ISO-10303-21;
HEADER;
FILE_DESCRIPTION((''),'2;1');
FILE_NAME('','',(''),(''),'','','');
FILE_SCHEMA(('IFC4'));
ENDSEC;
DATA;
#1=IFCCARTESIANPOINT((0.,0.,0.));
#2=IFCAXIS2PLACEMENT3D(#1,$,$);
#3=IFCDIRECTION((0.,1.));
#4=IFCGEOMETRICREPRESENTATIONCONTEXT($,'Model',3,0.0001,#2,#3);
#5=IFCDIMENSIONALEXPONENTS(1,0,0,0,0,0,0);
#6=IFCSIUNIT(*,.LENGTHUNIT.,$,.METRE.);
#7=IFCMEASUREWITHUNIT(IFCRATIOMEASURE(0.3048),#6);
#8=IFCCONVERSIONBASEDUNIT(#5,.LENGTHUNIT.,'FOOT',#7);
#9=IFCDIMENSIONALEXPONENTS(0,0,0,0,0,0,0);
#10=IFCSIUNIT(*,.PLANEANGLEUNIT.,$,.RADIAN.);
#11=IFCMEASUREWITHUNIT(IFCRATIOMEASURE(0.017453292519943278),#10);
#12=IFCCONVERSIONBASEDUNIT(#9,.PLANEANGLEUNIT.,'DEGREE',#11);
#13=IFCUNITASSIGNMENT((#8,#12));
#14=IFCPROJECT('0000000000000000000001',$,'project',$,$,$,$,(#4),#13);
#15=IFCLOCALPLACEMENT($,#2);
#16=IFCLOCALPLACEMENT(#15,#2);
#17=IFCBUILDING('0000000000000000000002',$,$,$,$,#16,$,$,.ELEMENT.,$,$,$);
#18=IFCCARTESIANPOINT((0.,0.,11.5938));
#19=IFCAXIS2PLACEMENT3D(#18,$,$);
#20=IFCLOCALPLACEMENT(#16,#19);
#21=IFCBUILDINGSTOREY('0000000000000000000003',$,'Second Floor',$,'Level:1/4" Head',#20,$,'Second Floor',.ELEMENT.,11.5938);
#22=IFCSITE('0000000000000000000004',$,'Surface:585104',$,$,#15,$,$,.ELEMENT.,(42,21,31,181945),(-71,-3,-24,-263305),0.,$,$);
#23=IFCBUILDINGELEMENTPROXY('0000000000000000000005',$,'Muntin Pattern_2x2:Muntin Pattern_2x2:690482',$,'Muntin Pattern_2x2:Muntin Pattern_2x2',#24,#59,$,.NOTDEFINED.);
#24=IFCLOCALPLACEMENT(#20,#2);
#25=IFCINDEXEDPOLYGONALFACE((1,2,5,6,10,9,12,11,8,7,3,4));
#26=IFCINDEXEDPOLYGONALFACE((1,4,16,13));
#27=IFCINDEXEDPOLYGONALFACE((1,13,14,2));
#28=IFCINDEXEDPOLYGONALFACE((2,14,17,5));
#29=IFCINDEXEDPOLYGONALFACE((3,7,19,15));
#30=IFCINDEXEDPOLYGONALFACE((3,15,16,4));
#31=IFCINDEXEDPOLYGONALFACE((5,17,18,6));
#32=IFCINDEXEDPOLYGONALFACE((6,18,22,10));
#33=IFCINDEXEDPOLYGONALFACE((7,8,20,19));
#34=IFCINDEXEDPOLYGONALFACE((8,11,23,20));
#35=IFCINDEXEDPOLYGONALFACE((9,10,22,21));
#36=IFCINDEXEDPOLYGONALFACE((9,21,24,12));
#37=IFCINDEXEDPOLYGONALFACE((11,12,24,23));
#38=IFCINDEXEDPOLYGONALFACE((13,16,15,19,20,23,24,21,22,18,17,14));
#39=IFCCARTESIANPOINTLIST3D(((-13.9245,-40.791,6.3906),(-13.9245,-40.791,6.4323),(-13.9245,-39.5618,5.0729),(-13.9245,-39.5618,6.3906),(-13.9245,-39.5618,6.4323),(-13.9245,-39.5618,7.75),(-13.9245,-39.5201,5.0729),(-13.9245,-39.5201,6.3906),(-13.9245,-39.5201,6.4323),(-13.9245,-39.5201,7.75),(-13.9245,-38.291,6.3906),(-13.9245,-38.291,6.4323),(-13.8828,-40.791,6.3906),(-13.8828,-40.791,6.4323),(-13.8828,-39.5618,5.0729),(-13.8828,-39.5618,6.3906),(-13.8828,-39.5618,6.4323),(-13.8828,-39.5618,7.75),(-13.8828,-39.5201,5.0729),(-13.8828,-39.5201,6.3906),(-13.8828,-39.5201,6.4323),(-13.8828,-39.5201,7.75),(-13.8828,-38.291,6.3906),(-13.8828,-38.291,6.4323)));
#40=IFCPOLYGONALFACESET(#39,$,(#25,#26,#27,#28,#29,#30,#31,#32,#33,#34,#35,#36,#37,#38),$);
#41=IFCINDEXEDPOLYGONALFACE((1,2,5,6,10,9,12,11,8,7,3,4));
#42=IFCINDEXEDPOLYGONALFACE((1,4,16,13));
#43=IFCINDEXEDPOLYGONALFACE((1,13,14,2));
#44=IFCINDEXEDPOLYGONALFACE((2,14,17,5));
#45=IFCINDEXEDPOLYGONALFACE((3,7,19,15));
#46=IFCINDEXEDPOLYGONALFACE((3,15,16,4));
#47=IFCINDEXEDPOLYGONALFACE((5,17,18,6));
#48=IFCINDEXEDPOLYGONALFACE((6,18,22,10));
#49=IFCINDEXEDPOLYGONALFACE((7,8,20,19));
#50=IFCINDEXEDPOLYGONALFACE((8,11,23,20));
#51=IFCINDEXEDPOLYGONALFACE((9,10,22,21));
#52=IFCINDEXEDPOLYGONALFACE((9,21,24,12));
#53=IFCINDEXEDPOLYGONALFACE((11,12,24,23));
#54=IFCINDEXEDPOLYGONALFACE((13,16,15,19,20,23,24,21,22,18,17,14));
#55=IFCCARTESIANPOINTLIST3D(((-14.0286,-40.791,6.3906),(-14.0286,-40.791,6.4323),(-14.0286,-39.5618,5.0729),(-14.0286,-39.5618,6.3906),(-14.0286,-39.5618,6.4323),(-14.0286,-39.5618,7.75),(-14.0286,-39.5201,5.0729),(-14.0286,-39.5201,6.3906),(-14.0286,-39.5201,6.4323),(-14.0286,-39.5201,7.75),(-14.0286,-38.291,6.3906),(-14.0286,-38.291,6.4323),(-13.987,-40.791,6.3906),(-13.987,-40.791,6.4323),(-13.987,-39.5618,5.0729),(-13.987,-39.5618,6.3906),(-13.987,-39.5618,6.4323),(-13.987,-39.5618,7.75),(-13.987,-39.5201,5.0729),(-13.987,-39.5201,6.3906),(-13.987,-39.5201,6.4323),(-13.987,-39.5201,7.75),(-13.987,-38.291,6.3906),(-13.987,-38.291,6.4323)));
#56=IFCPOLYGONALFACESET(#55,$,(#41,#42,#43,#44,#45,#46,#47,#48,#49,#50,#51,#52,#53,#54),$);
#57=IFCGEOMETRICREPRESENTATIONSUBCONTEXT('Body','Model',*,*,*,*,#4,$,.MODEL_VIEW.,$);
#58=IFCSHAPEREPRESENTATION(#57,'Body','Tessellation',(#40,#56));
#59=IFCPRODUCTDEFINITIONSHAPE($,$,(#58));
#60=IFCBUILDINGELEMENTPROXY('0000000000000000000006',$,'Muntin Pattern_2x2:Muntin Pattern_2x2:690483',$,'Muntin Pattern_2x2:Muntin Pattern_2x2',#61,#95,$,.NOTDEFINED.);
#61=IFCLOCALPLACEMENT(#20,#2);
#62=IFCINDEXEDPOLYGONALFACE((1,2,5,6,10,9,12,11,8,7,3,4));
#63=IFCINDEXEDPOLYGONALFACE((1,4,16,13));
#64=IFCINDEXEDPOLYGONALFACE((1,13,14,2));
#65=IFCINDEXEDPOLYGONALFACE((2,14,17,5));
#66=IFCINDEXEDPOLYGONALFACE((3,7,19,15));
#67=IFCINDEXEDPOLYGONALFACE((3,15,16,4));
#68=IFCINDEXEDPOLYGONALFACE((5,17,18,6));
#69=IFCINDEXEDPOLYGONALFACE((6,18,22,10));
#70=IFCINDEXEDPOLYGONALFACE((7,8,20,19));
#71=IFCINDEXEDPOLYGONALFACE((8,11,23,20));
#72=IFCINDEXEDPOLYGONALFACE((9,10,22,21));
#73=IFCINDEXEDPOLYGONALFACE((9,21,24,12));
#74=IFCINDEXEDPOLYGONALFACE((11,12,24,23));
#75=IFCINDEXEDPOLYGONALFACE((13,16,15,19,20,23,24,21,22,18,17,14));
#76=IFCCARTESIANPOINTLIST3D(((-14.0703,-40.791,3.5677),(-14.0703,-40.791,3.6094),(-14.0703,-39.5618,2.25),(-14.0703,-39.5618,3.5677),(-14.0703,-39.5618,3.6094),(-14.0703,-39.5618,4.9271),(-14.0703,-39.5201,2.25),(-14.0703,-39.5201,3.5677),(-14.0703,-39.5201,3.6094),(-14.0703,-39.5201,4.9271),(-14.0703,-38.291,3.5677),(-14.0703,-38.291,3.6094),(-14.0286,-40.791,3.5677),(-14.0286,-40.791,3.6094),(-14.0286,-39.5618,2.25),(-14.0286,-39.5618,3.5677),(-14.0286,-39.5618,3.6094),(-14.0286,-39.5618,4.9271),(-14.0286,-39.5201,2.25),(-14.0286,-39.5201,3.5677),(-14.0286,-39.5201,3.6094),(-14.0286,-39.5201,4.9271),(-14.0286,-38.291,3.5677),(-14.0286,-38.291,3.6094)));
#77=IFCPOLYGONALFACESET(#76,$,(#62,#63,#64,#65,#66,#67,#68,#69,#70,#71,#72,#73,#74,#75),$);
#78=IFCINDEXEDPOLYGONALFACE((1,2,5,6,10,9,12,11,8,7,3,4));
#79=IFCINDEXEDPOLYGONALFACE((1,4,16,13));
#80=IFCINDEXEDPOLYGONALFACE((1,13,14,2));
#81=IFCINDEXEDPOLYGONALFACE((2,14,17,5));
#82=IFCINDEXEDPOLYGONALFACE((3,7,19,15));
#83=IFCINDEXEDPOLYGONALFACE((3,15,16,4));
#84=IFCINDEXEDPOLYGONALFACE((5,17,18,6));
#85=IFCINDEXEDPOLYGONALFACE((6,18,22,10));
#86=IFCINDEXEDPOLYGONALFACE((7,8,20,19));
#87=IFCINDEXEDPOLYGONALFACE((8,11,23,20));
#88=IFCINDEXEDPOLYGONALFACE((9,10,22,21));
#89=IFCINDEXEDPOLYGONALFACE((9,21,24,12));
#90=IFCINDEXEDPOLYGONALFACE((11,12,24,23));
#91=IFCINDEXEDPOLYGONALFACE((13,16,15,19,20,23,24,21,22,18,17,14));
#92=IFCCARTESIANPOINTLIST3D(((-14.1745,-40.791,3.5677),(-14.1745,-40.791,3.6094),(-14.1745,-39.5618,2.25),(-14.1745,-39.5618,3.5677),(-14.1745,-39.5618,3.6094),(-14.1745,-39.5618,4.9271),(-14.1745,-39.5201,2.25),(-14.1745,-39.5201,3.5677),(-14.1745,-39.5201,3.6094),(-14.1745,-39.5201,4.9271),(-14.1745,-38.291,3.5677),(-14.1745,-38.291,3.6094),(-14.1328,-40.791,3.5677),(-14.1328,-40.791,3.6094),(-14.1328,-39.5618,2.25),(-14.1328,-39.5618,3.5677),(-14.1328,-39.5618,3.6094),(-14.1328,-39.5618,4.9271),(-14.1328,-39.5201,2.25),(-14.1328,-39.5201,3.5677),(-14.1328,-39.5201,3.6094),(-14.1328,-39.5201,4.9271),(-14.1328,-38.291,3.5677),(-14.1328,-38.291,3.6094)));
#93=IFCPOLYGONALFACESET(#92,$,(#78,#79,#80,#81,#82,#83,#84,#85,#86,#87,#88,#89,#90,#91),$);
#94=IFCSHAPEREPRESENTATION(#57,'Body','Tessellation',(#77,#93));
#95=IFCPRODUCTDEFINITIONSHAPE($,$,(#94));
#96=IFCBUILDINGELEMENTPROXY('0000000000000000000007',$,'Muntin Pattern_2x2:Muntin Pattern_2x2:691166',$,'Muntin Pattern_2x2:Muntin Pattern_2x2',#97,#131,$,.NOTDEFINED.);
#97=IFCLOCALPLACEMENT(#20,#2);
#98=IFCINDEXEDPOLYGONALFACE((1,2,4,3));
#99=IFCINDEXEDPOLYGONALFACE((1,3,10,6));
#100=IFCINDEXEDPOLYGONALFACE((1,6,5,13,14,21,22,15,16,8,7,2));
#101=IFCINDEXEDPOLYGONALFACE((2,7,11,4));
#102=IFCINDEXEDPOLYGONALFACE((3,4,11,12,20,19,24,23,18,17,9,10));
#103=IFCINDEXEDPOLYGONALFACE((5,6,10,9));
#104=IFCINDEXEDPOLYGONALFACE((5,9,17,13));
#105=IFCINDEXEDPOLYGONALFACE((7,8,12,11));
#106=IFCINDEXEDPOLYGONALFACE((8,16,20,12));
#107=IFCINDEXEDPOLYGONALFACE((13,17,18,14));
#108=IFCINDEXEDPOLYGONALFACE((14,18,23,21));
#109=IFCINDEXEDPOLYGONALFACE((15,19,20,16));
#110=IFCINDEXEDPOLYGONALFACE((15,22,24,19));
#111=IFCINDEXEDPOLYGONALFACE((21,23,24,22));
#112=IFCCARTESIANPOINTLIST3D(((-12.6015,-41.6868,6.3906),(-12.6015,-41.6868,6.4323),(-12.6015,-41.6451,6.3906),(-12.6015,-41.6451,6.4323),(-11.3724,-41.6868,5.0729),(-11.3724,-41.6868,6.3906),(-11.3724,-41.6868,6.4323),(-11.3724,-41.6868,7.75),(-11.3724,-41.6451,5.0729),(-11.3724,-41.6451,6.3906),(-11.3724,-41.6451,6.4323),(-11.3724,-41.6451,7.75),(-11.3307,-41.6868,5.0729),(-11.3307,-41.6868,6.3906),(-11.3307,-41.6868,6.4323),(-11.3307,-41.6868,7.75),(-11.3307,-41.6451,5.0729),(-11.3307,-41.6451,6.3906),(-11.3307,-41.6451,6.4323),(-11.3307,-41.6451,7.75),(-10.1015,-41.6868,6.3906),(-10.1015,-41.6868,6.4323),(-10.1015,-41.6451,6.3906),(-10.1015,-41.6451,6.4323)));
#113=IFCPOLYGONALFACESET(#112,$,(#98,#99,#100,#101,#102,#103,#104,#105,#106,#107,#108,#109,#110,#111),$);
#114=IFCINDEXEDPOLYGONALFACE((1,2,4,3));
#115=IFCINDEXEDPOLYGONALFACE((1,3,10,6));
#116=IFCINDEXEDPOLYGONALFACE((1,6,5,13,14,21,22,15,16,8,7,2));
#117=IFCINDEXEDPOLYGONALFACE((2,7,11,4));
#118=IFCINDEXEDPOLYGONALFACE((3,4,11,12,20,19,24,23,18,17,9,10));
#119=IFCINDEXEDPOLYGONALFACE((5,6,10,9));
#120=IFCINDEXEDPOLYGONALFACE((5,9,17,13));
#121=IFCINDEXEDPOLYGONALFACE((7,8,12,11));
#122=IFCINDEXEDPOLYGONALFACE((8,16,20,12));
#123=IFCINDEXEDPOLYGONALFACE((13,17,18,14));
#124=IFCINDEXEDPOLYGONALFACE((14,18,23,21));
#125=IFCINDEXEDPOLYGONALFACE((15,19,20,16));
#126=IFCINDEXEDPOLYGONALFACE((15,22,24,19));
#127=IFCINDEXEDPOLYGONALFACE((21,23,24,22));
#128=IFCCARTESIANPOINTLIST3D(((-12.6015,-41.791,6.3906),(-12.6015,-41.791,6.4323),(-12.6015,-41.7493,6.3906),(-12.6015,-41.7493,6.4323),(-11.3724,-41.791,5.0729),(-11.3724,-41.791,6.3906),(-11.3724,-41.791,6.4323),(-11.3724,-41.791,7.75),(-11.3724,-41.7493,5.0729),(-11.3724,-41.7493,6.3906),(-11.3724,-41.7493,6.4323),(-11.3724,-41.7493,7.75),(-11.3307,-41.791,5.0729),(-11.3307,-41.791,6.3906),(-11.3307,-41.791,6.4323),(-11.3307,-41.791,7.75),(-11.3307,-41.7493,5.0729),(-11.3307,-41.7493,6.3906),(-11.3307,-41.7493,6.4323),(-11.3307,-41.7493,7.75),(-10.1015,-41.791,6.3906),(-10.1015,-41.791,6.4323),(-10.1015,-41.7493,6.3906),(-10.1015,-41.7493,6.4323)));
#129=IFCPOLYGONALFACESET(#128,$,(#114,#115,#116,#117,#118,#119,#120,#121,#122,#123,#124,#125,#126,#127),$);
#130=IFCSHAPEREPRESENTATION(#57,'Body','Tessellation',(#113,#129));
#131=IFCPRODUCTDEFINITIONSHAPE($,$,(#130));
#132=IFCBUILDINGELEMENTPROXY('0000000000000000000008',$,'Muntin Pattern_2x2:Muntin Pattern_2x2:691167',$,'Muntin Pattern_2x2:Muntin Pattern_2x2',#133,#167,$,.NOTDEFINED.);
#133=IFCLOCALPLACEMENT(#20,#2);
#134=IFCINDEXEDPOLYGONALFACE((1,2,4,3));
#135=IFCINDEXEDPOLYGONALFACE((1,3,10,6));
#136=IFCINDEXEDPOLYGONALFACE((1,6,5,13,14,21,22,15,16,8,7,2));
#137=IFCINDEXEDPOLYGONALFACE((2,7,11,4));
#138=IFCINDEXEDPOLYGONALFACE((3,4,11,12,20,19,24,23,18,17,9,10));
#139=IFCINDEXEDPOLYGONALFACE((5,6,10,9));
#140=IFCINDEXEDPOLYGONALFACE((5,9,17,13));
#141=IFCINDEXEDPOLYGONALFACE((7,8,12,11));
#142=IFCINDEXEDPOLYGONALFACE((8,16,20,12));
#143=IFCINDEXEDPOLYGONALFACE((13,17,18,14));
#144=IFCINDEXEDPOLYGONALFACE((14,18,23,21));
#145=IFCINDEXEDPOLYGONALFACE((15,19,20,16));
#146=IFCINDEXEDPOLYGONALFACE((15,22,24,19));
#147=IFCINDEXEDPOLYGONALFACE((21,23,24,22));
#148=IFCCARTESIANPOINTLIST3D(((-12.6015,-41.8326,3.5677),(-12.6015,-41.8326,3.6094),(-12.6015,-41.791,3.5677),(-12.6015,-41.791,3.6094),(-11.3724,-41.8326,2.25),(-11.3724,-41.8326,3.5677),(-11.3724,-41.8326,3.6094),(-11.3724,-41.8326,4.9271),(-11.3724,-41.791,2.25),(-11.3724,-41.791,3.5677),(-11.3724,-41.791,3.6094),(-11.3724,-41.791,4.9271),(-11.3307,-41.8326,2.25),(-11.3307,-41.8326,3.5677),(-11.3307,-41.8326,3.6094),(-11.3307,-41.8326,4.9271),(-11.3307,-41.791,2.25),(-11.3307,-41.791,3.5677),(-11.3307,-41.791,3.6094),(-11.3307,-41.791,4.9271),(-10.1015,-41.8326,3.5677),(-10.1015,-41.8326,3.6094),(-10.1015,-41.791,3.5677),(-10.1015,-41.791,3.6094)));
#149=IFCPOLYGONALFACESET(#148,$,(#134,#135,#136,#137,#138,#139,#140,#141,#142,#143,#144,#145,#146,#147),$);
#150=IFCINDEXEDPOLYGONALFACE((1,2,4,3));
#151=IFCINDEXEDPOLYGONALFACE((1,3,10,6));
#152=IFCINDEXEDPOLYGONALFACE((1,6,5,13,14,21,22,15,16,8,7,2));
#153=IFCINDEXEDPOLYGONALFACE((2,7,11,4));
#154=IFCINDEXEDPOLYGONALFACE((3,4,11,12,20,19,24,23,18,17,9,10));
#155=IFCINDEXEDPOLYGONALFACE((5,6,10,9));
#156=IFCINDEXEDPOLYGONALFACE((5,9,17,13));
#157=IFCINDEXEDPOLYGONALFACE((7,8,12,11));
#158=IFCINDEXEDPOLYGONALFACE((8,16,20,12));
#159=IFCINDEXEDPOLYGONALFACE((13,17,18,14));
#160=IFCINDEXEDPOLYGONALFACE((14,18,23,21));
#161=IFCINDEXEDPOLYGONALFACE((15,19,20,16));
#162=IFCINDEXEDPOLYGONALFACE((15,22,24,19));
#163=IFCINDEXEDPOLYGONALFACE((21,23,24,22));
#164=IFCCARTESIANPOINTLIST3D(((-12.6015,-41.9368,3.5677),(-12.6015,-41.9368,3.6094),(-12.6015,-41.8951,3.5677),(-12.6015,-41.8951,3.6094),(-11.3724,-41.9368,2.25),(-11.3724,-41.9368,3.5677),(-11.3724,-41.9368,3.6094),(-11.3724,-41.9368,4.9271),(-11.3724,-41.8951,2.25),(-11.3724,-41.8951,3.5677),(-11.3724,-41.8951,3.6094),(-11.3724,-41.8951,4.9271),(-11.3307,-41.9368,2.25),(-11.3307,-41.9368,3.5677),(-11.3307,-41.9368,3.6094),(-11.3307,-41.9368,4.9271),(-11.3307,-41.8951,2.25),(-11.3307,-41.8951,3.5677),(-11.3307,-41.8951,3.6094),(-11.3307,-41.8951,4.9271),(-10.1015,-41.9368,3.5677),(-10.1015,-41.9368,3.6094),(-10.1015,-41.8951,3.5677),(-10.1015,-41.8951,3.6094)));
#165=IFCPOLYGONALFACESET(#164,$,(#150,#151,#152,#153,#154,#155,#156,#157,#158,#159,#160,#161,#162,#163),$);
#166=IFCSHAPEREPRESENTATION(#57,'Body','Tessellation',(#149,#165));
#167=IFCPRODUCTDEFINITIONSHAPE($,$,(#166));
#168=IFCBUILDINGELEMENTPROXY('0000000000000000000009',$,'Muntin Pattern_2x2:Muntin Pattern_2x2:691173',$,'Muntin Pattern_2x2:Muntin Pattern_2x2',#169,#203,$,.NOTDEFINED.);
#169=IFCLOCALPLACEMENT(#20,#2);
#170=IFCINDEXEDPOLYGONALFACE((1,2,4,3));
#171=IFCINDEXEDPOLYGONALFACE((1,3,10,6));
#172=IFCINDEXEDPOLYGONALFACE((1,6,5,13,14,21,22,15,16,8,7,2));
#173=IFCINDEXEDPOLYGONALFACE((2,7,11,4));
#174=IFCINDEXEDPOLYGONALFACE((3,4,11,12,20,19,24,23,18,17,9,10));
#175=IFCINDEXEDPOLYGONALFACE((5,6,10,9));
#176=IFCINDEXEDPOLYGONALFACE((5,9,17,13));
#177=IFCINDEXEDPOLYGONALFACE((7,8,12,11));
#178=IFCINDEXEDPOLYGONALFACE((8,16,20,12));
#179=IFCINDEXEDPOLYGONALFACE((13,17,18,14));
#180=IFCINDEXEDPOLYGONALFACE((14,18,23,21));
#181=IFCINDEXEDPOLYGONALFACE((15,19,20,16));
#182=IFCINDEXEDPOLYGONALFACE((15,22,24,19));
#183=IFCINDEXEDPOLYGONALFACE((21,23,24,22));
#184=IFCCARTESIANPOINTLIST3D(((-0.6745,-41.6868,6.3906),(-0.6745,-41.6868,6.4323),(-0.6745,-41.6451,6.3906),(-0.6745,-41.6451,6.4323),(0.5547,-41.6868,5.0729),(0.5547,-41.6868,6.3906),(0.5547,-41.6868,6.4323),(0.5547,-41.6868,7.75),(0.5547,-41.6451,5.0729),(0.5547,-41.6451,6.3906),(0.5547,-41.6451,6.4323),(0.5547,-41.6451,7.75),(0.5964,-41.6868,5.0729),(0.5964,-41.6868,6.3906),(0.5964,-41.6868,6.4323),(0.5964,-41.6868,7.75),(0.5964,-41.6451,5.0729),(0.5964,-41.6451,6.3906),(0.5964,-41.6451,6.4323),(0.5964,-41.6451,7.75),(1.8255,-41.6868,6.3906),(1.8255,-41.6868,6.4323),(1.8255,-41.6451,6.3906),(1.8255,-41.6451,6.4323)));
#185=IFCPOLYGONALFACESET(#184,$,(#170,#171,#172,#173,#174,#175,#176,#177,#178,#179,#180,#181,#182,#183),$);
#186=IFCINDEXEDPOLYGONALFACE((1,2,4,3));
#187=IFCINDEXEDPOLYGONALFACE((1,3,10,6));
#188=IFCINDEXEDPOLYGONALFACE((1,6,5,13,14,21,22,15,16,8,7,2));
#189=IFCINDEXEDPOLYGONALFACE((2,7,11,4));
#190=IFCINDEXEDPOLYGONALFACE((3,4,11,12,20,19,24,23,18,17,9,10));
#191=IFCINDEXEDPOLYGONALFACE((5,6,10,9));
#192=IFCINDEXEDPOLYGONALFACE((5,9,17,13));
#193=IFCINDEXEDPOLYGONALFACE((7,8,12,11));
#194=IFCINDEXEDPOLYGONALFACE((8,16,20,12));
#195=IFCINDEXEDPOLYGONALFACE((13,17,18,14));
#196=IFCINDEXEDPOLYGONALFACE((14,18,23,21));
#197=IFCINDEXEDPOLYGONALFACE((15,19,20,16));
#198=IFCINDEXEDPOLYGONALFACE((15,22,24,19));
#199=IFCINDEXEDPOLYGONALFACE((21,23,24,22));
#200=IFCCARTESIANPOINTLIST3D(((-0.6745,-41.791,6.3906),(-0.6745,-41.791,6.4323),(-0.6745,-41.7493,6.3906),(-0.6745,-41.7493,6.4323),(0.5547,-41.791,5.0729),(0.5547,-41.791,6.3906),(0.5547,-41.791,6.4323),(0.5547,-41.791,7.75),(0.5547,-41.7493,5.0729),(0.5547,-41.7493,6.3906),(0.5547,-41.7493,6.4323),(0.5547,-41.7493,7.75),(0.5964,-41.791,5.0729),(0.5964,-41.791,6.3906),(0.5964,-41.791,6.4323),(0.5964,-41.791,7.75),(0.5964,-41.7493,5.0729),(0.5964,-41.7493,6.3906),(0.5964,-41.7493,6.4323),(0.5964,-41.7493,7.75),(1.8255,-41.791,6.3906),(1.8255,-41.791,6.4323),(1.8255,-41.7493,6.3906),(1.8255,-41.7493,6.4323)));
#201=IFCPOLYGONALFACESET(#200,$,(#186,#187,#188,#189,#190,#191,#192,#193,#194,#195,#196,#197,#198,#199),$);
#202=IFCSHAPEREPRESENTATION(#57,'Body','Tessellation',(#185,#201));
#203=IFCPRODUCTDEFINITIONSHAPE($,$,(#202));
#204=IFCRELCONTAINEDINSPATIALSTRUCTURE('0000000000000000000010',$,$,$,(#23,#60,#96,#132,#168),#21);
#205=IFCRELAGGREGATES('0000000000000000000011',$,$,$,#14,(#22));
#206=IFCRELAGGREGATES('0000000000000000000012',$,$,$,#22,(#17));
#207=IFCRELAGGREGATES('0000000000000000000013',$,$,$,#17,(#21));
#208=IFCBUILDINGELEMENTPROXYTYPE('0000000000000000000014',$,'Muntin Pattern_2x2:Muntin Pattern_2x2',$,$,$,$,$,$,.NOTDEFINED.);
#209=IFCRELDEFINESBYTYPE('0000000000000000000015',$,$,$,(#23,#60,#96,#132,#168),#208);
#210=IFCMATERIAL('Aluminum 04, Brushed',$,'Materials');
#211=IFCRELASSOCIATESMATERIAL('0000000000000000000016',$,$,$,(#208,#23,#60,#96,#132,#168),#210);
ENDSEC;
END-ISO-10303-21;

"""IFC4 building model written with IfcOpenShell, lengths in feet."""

from ifc_helpers import new_model, entity, si_unit, converted_unit, direction, frame, origin, place, context, subcontext, project, spatial, indexed_curve, outline, extrude, source, transform, mapped, material, type_object, type_shapes, element, save


model = new_model("IFC4")

# Units and contexts
model_context = context("Model", 3, precision=0.0001, world=origin(), true_north=direction((0.0, 1.0)))
body_context = subcontext(model_context, "Body", "Model", "MODEL_VIEW")
ifc_project = project(units=[converted_unit("LENGTHUNIT", "FOOT", entity("IfcRatioMeasure", 0.3048), si_unit("LENGTHUNIT", "METRE"), dimensions=[1, 0, 0, 0, 0, 0, 0]), converted_unit("PLANEANGLEUNIT", "DEGREE", entity("IfcRatioMeasure", 0.017453292519943278), si_unit("PLANEANGLEUNIT", "RADIAN"), dimensions=[0, 0, 0, 0, 0, 0, 0])], contexts=[model_context])

# Site, building, storey
site_placement = place(None, origin())
site = spatial("IfcSite", under=ifc_project, at=site_placement, Name="Surface:585104", CompositionType="ELEMENT", RefLatitude=(42, 21, 31, 181945), RefLongitude=(-71, -3, -24, -263305), RefElevation=0.0)
building_placement = place(site_placement, origin())
building = spatial("IfcBuilding", under=site, at=building_placement, CompositionType="ELEMENT")
storey_placement = place(building_placement, frame((0.0, 0.0, 11.5938)))
storey = spatial("IfcBuildingStorey", under=building, at=storey_placement, Name="Second Floor", ObjectType="Level:1/4\" Head", LongName="Second Floor", CompositionType="ELEMENT", Elevation=11.5938)

# Building element proxies
ifc_material_1 = material(Name="Aluminum 04, Brushed", Category="Materials")
building_element_proxy_type_1 = type_object("IfcBuildingElementProxyType", Name="Muntin Pattern_2x2:Muntin Pattern_2x2", PredefinedType="NOTDEFINED", material=ifc_material_1)
shared_shape_1 = source(origin(), body_context, "Body", "SweptSolid", [
    extrude(outline(indexed_curve([(0.0208, -0.0208), (1.3385, -0.0208), (1.3385, 0.0208), (0.0208, 0.0208), (0.0208, 1.25), (-0.0208, 1.25), (-0.0208, 0.0208), (-1.3385, 0.0208), (-1.3385, -0.0208), (-0.0208, -0.0208), (-0.0208, -1.25), (0.0208, -1.25), (0.0208, -0.0208)], self_intersect=False)), frame((0.0, -0.0729, 1.3385), z_axis=(0.0, 1.0, 0.0), x_axis=(0.0, 0.0, 1.0)), (0.0, 0.0, 1.0), 0.0417),
    extrude(outline(indexed_curve([(0.0208, -0.0208), (1.3385, -0.0208), (1.3385, 0.0208), (0.0208, 0.0208), (0.0208, 1.25), (-0.0208, 1.25), (-0.0208, 0.0208), (-1.3385, 0.0208), (-1.3385, -0.0208), (-0.0208, -0.0208), (-0.0208, -1.25), (0.0208, -1.25), (0.0208, -0.0208)], self_intersect=False)), frame((0.0, 0.0313, 1.3385), z_axis=(0.0, 1.0, 0.0), x_axis=(0.0, 0.0, 1.0)), (0.0, 0.0, 1.0), 0.0417),
])
type_shapes(building_element_proxy_type_1, [shared_shape_1])
for number, where, z_axis, x_axis, name in (
    (1, (-13.9557, -39.541, 5.0729), (0.0, 0.0, 1.0), (0.0, 1.0, 0.0), "Muntin Pattern_2x2:Muntin Pattern_2x2:690482"),
    (2, (-14.1015, -39.541, 2.25), (0.0, 0.0, 1.0), (0.0, 1.0, 0.0), "Muntin Pattern_2x2:Muntin Pattern_2x2:690483"),
    (3, (-11.3515, -41.718, 5.0729), (0.0, 0.0, 1.0), (-1.0, 0.0, 0.0), "Muntin Pattern_2x2:Muntin Pattern_2x2:691166"),
    (4, (-11.3515, -41.8639, 2.25), (0.0, 0.0, 1.0), (-1.0, 0.0, 0.0), "Muntin Pattern_2x2:Muntin Pattern_2x2:691167"),
    (5, (0.5755, -41.718, 5.0729), (0.0, 0.0, 1.0), (-1.0, 0.0, 0.0), "Muntin Pattern_2x2:Muntin Pattern_2x2:691173"),
):
    element("IfcBuildingElementProxy", number, at=place(storey_placement, frame(where, z_axis=z_axis, x_axis=x_axis)), inside=storey, type_object=building_element_proxy_type_1, material=ifc_material_1, Name=name, ObjectType="Muntin Pattern_2x2:Muntin Pattern_2x2", PredefinedType="NOTDEFINED", context=body_context, shape_type="MappedRepresentation", body=[
        mapped(shared_shape_1, transform((0.0, 0.0, 0.0), scale=1.0)),
    ])

save(model, "model.ifc")
